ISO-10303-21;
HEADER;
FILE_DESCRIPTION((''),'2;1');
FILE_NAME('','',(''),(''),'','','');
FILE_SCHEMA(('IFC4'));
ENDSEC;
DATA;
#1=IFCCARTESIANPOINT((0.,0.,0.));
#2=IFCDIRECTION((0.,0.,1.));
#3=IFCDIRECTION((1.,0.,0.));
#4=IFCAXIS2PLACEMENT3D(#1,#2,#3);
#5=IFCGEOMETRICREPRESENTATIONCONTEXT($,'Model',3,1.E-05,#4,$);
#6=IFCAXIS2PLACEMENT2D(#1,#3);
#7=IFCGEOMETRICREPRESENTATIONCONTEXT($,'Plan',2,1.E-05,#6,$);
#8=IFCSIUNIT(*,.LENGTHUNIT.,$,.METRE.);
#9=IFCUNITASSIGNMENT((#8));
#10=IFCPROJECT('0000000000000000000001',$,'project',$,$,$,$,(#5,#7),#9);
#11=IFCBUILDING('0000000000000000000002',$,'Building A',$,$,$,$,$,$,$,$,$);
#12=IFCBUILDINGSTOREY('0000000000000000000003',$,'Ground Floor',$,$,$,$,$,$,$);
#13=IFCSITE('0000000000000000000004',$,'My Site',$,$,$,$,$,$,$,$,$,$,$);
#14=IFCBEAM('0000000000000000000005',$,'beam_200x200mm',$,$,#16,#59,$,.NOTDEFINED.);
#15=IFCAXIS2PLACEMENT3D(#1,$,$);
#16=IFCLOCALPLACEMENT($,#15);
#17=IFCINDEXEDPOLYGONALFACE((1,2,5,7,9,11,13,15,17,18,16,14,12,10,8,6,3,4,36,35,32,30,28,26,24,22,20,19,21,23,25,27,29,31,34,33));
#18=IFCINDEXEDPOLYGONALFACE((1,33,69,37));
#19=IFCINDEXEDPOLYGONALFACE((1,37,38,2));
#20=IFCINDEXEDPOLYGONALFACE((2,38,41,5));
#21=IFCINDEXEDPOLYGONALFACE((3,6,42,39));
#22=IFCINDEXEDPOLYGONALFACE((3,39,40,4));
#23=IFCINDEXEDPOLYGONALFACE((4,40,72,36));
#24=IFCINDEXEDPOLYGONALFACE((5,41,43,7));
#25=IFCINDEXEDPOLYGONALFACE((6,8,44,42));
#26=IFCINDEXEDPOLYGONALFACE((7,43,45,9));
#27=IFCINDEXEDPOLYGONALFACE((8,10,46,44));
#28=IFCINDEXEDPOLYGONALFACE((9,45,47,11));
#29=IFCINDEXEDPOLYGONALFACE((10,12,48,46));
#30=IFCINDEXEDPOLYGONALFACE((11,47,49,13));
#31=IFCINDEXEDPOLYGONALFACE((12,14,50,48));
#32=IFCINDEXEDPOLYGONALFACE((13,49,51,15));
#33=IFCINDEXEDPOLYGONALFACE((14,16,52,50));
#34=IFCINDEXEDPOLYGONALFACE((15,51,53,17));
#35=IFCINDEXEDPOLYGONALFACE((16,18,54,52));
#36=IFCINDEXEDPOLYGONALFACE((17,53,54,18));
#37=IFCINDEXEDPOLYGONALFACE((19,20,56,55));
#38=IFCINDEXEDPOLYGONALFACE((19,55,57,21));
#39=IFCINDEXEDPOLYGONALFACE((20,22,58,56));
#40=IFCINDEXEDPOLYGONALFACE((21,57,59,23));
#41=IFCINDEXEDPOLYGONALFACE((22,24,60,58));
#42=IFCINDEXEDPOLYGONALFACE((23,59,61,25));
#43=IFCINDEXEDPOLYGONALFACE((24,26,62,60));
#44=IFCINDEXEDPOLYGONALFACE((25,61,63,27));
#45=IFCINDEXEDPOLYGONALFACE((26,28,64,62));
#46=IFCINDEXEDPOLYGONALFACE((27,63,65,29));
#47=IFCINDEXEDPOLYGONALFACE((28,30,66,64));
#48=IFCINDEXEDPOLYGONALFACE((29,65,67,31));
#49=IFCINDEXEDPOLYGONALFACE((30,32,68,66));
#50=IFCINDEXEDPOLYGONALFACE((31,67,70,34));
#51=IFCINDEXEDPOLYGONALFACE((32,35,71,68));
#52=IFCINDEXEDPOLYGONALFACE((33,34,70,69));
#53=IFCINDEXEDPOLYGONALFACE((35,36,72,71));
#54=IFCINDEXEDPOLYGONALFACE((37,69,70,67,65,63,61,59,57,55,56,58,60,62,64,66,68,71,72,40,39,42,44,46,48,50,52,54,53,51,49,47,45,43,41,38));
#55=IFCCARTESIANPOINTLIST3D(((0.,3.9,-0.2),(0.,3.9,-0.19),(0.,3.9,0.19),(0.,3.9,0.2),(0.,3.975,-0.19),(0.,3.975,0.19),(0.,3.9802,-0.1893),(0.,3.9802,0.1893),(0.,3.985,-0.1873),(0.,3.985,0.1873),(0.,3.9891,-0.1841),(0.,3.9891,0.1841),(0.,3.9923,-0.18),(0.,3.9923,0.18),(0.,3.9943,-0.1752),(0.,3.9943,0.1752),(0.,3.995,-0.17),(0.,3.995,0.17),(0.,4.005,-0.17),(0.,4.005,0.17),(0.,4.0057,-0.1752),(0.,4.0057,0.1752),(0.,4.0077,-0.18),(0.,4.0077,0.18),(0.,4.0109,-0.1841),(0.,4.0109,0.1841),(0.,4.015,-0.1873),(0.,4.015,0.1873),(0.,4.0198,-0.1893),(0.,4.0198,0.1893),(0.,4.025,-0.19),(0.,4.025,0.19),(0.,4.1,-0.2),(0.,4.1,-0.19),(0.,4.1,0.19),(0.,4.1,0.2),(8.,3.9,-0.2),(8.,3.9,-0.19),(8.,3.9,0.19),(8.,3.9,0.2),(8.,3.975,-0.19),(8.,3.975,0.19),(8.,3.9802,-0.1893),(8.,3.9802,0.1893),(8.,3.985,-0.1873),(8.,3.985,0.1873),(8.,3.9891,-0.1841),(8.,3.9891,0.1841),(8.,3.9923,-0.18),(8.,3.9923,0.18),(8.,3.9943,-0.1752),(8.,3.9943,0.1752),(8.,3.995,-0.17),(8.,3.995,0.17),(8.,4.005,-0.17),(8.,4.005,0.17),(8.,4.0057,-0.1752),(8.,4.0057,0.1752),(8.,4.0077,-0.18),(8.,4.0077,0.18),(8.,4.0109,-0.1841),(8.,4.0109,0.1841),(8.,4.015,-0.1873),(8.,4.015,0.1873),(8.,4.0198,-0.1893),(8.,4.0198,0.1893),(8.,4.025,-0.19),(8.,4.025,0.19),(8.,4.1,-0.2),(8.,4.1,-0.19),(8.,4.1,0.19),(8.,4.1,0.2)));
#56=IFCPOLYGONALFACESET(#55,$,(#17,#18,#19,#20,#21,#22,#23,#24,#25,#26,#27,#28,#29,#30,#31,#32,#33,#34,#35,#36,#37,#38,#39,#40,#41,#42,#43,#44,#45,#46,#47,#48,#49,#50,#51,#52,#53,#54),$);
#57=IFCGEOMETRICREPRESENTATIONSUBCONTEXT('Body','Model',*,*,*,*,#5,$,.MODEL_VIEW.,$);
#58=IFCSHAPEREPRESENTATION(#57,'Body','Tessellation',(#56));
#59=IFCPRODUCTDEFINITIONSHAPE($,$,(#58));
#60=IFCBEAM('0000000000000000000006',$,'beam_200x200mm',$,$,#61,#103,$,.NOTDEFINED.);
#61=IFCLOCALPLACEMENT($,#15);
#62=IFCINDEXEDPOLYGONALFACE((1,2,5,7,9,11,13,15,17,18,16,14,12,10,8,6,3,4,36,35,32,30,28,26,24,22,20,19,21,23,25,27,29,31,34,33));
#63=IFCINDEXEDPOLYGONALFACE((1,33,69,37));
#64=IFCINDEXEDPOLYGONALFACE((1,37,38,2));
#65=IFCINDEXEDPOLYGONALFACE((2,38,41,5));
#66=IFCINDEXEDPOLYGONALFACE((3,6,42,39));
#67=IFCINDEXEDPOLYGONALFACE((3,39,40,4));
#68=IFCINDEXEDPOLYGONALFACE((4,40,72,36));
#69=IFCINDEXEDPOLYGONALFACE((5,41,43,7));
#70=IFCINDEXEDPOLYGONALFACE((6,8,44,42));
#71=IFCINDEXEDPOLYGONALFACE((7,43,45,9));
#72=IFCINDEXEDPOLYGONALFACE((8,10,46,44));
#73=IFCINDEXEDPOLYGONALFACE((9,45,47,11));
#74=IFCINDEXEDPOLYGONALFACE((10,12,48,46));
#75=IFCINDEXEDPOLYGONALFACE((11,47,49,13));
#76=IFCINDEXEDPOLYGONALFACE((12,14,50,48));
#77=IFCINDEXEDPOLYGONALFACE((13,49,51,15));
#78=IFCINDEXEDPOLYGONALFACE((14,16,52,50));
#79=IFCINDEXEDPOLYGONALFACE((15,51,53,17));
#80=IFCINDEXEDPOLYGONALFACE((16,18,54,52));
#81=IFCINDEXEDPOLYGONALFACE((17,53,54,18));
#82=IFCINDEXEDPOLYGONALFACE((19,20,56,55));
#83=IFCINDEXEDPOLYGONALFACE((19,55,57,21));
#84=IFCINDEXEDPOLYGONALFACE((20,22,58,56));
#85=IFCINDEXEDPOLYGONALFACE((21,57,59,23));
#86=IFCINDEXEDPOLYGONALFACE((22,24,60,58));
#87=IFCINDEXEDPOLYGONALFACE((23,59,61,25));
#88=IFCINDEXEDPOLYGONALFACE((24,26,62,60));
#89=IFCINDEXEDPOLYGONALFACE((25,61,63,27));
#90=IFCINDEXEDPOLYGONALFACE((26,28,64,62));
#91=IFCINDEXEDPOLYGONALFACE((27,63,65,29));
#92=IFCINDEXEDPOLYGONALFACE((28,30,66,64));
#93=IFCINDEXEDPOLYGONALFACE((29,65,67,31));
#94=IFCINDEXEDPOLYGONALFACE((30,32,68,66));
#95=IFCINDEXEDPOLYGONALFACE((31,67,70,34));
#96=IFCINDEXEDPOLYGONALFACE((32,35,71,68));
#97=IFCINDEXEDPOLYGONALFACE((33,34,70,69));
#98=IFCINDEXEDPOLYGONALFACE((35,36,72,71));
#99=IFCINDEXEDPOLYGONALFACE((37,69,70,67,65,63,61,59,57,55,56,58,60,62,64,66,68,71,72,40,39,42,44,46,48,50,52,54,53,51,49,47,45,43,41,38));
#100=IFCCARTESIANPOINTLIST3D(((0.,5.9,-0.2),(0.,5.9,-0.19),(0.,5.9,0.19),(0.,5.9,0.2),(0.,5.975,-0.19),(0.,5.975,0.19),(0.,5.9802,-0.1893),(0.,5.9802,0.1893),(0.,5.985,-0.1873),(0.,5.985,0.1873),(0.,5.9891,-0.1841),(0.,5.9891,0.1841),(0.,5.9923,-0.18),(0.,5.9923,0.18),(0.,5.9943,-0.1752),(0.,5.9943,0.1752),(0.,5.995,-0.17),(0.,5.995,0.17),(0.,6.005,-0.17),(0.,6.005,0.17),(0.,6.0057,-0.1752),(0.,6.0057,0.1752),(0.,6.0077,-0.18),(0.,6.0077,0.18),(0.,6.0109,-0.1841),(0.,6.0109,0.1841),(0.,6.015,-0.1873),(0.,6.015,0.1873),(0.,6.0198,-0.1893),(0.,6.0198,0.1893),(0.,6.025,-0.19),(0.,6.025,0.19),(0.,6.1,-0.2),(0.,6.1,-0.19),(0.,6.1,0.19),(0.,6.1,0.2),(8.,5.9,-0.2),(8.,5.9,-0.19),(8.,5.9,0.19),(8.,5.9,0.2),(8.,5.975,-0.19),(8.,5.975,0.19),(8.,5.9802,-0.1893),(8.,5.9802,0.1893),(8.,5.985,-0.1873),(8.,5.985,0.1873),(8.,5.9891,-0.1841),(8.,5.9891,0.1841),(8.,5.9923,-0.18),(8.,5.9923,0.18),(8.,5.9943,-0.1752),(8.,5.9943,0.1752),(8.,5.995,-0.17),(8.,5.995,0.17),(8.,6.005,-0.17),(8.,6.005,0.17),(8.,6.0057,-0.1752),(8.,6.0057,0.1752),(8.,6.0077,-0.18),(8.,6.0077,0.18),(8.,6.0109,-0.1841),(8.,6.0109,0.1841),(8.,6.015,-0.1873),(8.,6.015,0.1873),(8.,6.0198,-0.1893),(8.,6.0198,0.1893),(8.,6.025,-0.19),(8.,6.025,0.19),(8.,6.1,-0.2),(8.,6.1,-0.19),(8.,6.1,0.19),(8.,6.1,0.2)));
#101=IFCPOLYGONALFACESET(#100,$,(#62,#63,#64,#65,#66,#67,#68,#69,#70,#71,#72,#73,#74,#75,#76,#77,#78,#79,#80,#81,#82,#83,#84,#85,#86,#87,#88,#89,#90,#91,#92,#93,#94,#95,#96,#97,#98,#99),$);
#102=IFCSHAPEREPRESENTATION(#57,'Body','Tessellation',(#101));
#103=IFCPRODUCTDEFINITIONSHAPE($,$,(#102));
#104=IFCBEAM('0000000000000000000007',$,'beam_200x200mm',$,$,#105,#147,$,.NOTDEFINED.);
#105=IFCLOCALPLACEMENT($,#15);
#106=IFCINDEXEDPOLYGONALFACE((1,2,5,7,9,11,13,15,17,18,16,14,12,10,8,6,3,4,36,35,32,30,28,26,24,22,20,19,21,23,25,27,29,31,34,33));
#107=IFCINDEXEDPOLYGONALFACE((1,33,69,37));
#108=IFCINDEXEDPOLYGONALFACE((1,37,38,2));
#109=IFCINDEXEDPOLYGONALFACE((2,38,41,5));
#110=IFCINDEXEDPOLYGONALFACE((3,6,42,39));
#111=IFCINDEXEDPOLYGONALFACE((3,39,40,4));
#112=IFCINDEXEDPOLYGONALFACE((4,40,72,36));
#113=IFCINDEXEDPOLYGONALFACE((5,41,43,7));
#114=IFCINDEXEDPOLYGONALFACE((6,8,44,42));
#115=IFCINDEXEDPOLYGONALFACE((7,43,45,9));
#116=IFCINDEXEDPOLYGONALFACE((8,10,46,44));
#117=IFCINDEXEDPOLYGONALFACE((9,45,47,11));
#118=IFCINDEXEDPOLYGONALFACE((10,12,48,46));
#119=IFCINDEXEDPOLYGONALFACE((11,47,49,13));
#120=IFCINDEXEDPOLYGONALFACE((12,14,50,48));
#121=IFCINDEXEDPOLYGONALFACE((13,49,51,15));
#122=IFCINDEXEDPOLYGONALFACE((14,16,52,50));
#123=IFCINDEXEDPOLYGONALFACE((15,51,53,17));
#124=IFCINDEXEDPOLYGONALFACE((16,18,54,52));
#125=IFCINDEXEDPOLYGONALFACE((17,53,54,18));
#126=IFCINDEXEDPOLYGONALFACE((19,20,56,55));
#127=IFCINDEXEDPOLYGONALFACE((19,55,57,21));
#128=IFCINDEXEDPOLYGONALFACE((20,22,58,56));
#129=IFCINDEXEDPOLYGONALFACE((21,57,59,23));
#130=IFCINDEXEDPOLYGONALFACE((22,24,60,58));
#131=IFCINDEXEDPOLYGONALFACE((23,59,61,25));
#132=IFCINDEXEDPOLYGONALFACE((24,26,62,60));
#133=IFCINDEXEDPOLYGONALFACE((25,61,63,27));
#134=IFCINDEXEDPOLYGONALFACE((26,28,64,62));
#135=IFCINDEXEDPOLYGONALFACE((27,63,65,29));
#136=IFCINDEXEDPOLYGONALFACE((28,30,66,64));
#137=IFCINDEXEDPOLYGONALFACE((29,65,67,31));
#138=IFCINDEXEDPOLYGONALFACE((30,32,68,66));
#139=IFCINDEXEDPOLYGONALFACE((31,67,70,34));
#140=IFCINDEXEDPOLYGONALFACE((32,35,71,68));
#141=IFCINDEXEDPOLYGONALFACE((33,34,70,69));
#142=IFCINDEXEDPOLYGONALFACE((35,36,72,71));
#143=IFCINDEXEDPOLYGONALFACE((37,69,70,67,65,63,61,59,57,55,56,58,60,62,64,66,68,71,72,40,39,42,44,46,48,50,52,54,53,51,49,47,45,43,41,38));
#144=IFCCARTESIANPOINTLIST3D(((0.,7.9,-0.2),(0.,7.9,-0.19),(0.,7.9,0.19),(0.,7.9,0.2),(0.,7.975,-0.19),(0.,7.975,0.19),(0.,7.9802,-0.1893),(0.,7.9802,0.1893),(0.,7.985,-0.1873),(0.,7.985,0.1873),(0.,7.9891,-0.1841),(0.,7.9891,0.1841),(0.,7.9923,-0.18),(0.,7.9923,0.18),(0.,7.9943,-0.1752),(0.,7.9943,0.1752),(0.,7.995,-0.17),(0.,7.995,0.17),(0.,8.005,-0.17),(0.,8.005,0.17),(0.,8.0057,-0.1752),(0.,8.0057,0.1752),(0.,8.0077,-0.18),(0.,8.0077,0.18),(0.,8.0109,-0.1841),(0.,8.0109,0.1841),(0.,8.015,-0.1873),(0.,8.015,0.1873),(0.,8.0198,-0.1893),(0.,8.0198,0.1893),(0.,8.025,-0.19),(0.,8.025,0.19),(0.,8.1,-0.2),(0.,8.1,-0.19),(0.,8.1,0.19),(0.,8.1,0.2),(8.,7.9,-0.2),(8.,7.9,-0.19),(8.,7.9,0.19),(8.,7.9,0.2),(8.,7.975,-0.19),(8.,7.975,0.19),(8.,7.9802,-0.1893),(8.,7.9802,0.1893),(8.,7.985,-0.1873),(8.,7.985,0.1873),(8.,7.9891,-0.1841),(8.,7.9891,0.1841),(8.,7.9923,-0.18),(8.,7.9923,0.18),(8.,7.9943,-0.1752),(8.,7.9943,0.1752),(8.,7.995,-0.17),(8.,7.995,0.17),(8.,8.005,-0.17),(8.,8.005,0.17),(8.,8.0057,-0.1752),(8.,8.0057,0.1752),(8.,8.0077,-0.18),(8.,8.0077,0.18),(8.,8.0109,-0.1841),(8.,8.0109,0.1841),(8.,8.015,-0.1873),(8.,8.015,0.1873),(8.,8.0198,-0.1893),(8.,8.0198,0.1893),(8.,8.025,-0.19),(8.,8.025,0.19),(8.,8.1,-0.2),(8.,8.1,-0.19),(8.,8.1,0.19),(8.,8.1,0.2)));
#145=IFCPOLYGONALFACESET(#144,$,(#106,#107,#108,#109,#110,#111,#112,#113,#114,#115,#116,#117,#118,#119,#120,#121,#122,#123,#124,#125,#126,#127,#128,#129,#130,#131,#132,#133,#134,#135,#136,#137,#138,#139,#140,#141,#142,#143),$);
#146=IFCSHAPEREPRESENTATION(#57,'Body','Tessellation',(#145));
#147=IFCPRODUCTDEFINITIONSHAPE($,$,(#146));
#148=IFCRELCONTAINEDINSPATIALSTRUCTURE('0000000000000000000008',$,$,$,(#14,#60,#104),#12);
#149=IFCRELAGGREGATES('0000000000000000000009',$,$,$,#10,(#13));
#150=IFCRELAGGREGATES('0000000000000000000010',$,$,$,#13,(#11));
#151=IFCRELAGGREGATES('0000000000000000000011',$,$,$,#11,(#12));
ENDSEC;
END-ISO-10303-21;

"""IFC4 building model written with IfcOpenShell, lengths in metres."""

from ifc_helpers import new_model, entity, si_unit, frame, frame_2d, origin_with_axes, place, context, subcontext, project, spatial, extrude, element, save


model = new_model("IFC4")

# Units and contexts
model_context = context("Model", 3, precision=1e-05, world=origin_with_axes())
plan_context = context("Plan", 2, precision=1e-05, world=frame_2d((0.0, 0.0, 0.0), x_axis=(1.0, 0.0, 0.0)))
body_context = subcontext(model_context, "Body", "Model", "MODEL_VIEW")
ifc_project = project(units=[si_unit("LENGTHUNIT", "METRE")], contexts=[model_context, plan_context])

# Site, building, storey
site = spatial("IfcSite", under=ifc_project, Name="My Site")
building = spatial("IfcBuilding", under=site, Name="Building A")
storey = spatial("IfcBuildingStorey", under=building, Name="Ground Floor")

# Beams
for number, where, z_axis, x_axis, name in (
    (1, (0.0, 4.0, 0.0), (1.0, 0.0, 0.0), (0.0, 1.0, 0.0), "beam_200x200mm"),
    (2, (0.0, 6.0, 0.0), (1.0, 0.0, 0.0), (0.0, 1.0, 0.0), "beam_200x200mm"),
    (3, (0.0, 8.0, 0.0), (1.0, 0.0, 0.0), (0.0, 1.0, 0.0), "beam_200x200mm"),
):
    element("IfcBeam", number, at=place(None, frame(where, z_axis=z_axis, x_axis=x_axis)), inside=storey, Name=name, PredefinedType="NOTDEFINED", context=body_context, shape_type="SweptSolid", body=[
        extrude(entity("IfcIShapeProfileDef", None, None, None, 0.2, 0.4, 0.01, 0.01, 0.02), origin_with_axes(), (0.0, 0.0, 1.0), 8.0),
    ])

save(model, "model.ifc")
